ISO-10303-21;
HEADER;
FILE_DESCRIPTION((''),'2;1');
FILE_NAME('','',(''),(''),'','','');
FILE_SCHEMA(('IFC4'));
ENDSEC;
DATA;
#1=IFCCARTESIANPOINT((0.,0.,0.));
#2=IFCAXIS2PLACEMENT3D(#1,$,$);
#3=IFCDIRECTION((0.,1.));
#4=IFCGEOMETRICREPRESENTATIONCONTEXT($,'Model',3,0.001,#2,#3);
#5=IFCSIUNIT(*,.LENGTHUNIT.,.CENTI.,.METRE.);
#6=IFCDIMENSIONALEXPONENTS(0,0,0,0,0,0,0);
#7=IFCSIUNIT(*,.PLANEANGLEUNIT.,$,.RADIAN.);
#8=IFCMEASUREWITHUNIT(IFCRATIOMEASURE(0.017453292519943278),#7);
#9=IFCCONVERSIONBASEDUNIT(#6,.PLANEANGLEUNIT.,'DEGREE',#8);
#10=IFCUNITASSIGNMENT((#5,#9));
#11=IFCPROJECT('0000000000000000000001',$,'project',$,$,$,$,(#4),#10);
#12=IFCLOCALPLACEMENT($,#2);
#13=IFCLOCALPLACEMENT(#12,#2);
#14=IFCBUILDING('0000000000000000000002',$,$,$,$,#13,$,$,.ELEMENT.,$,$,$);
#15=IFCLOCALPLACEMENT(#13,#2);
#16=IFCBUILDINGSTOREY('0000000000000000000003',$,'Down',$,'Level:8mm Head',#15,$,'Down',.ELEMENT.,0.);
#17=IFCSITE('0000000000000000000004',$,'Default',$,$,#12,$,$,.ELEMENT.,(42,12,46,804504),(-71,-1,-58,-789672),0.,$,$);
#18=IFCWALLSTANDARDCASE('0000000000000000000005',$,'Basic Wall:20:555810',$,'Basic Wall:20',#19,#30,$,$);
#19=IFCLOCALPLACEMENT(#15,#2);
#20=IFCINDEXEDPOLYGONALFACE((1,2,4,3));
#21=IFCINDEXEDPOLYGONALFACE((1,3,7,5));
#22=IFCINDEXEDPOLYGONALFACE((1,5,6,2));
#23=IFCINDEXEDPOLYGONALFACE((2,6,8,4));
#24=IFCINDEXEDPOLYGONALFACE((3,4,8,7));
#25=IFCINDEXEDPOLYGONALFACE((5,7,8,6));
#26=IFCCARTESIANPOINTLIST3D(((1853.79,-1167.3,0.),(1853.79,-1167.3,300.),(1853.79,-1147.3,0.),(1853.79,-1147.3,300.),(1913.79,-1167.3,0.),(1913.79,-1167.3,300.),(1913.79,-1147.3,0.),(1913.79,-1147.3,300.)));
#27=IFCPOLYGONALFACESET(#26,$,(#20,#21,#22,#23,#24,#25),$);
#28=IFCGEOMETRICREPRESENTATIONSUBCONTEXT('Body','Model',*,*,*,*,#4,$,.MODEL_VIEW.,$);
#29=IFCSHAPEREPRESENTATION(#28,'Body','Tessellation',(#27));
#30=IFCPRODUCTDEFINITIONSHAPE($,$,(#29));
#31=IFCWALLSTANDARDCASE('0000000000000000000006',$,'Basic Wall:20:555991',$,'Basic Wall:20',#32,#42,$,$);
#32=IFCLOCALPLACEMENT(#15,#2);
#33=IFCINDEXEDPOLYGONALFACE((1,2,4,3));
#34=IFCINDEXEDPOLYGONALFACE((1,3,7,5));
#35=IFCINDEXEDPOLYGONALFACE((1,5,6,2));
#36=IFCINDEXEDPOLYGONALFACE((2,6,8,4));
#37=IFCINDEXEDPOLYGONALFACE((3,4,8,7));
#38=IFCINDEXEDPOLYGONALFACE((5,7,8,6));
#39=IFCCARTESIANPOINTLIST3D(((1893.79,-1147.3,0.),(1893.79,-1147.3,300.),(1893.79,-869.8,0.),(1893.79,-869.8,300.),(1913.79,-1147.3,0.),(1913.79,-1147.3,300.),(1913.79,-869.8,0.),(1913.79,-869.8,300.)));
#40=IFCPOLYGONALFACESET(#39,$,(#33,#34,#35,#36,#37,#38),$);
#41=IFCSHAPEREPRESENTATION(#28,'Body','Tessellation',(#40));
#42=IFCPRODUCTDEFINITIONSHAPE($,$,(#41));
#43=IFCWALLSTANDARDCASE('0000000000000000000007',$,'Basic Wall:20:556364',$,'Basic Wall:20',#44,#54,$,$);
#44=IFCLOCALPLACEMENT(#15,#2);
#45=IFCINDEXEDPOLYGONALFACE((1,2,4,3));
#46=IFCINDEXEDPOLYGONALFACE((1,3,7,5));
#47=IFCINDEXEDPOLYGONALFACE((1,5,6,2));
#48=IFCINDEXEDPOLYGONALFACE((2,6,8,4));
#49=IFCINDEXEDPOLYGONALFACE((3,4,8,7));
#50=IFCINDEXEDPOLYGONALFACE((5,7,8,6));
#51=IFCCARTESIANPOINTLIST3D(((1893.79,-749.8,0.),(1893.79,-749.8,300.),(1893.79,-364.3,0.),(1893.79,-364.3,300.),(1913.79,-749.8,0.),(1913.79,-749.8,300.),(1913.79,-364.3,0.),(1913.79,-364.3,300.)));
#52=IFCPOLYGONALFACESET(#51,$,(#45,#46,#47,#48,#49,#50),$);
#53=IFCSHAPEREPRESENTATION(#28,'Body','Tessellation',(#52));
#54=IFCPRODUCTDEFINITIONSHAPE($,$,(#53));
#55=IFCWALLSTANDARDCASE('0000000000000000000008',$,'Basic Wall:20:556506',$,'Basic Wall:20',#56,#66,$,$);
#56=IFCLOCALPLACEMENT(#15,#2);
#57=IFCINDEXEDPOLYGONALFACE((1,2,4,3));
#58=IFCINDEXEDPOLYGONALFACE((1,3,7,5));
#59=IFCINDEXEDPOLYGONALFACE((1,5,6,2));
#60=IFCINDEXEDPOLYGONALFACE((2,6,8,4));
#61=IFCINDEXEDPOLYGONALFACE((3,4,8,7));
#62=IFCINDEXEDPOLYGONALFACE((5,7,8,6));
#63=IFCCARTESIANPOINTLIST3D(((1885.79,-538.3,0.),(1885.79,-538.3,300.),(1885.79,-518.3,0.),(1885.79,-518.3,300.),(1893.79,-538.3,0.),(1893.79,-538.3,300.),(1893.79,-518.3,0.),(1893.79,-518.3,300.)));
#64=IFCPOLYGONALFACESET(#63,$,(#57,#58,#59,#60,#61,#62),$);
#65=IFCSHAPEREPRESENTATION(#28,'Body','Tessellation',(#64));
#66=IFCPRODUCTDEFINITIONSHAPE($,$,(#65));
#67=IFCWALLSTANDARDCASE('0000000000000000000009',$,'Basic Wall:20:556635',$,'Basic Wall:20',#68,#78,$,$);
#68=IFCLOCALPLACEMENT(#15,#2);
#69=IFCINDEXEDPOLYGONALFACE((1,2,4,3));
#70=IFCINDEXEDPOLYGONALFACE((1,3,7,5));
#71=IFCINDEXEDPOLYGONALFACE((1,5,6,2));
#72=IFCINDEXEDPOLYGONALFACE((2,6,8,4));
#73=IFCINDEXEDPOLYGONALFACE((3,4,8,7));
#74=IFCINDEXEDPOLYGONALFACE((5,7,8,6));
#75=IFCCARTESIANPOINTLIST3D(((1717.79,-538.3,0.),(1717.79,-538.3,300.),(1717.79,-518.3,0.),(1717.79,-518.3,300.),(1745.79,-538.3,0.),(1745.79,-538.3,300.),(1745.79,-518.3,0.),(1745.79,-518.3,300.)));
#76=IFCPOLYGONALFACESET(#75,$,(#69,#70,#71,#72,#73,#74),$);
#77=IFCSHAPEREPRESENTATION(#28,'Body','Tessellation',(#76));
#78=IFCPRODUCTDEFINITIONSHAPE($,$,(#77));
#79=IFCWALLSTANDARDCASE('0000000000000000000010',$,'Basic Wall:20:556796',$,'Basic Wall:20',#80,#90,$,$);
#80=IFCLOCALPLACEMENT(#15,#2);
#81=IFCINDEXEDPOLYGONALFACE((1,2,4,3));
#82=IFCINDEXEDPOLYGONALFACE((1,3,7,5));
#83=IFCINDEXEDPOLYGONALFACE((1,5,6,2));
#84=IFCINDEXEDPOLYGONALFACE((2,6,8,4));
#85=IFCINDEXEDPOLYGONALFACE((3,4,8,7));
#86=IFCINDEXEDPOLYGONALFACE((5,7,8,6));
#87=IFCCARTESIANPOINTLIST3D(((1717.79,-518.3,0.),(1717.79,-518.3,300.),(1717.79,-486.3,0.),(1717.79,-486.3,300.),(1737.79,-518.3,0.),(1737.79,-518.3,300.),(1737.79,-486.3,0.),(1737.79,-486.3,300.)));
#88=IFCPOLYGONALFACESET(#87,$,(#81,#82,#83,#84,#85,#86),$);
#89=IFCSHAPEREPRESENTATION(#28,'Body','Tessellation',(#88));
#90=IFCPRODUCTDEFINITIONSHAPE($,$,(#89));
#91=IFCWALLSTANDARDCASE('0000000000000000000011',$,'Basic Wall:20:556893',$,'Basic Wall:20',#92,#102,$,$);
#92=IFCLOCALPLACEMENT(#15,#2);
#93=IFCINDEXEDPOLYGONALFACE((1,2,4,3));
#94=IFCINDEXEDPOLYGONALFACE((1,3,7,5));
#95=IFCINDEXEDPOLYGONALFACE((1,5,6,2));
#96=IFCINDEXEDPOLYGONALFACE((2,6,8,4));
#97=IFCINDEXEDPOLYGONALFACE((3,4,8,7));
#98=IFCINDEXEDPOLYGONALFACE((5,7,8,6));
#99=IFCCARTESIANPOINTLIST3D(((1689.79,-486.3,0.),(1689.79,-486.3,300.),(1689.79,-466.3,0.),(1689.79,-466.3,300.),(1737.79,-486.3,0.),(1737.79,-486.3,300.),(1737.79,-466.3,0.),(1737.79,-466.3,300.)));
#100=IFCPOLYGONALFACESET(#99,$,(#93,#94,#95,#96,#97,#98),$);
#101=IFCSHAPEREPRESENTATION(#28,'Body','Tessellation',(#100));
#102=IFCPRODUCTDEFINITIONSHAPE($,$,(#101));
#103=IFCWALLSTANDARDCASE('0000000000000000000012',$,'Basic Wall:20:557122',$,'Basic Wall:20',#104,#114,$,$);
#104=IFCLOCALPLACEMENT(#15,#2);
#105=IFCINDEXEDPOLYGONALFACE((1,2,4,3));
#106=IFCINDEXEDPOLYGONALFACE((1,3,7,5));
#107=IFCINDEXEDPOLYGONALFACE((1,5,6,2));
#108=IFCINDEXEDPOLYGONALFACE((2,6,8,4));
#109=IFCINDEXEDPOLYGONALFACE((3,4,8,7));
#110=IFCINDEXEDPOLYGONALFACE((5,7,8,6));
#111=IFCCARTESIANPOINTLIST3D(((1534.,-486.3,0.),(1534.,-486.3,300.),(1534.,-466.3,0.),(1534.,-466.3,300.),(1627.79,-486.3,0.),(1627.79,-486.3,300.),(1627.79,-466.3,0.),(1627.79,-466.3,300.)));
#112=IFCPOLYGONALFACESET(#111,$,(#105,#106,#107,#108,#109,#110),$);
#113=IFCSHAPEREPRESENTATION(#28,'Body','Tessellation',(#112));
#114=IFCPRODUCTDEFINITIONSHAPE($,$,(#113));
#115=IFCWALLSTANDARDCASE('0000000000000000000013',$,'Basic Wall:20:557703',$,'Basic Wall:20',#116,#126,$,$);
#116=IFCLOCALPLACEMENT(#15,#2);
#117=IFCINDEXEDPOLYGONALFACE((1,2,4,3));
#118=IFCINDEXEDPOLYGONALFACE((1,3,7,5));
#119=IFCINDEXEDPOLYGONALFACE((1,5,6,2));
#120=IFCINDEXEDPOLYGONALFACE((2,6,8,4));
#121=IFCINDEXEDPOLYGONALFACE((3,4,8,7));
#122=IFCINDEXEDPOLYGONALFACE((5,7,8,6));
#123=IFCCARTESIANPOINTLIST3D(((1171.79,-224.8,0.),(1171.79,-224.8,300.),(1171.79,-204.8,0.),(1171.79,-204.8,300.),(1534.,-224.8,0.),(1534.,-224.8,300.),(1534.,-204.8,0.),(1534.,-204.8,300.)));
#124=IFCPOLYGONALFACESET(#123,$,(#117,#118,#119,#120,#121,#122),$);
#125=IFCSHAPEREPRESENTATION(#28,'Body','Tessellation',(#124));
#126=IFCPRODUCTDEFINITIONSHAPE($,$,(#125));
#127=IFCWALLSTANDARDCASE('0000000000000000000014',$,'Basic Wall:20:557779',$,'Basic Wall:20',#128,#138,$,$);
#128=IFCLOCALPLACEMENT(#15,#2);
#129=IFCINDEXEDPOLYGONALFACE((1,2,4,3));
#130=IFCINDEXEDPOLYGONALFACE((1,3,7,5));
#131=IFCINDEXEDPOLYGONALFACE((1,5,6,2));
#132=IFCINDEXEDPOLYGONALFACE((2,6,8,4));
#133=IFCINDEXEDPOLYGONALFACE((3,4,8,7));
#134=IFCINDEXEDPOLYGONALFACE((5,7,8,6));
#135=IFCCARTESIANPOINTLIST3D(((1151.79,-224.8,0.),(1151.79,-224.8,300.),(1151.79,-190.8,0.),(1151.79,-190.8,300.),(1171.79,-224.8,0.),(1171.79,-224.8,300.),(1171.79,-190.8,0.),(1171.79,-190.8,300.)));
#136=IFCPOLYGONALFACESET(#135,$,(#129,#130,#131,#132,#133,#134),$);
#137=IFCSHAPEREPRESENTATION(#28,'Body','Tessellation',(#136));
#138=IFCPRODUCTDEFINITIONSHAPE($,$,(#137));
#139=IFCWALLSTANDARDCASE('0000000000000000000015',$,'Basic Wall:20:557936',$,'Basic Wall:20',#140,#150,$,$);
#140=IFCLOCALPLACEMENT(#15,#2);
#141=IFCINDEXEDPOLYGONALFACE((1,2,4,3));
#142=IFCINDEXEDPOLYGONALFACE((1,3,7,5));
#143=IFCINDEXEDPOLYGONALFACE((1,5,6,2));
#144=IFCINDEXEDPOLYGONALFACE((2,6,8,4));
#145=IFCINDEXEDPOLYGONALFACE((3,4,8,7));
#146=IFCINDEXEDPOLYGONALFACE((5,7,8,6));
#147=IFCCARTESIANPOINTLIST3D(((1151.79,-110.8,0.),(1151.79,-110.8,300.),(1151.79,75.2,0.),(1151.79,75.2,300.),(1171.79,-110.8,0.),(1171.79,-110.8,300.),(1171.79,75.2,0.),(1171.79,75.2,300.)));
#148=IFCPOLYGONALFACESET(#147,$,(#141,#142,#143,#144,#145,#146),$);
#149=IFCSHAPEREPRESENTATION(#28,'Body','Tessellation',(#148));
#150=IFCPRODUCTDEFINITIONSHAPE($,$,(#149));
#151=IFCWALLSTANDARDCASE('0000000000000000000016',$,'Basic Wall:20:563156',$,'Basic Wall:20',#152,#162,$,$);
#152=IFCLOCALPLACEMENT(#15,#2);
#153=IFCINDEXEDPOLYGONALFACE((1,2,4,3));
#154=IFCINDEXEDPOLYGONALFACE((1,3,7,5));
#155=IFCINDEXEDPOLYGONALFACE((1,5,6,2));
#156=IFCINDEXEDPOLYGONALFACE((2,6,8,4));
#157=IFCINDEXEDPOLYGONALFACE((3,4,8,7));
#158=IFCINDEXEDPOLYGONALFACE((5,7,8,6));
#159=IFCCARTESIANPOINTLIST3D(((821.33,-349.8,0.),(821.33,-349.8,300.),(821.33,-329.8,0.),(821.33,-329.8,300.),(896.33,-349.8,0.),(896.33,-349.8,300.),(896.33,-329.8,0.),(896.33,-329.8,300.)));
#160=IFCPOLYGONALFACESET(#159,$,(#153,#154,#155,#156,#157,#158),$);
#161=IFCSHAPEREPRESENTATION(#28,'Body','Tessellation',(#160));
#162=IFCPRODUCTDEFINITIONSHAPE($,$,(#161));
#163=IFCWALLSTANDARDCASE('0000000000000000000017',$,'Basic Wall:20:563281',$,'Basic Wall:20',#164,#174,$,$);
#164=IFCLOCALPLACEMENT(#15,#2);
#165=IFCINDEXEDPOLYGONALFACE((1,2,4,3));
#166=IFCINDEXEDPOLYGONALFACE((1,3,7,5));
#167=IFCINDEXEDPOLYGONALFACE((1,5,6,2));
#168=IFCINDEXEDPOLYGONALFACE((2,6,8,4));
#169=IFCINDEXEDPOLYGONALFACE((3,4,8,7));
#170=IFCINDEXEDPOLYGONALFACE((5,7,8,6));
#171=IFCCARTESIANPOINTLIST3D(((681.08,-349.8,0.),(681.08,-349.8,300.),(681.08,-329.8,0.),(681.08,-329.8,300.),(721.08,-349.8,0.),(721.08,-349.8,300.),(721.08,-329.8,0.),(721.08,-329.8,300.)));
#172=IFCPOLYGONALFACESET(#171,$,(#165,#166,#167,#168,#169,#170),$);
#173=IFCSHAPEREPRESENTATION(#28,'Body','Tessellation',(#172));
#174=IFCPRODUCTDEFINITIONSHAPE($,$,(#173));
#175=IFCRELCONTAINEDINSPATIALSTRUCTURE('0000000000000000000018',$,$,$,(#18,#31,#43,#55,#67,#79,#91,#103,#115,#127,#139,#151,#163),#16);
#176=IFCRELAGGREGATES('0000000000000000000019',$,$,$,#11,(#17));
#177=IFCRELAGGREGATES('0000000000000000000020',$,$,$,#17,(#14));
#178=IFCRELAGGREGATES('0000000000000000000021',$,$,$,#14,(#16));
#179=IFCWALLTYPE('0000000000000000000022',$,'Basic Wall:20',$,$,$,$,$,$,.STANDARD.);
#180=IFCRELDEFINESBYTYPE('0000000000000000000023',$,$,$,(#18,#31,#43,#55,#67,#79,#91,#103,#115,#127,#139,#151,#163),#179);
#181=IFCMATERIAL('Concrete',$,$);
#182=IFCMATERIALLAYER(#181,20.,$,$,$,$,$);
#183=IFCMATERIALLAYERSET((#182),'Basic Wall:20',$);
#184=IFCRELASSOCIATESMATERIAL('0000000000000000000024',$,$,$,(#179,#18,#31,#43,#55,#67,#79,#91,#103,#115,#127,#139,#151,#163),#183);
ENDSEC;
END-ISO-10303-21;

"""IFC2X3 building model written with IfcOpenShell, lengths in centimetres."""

from ifc_helpers import new_model, entity, si_unit, converted_unit, direction, frame, frame_2d, origin, place, context, subcontext, project, spatial, rectangle, extrude, material, layer, layer_set, layer_usage, type_object, element, save


model = new_model("IFC2X3")

# Units and contexts
model_context = context("Model", 3, precision=0.001, world=origin(), true_north=direction((0.0, 1.0)))
body_context = subcontext(model_context, "Body", "Model", "MODEL_VIEW")
ifc_project = project(units=[si_unit("LENGTHUNIT", "METRE", prefix="CENTI"), converted_unit("PLANEANGLEUNIT", "DEGREE", entity("IfcRatioMeasure", 0.017453292519943278), si_unit("PLANEANGLEUNIT", "RADIAN"), dimensions=[0, 0, 0, 0, 0, 0, 0])], contexts=[model_context])

# Site, building, storey
site_placement = place(None, origin())
site = spatial("IfcSite", under=ifc_project, at=site_placement, Name="Default", CompositionType="ELEMENT", RefLatitude=(42, 12, 46, 804504), RefLongitude=(-71, -1, -58, -789672), RefElevation=0.0)
building_placement = place(site_placement, origin())
building = spatial("IfcBuilding", under=site, at=building_placement, CompositionType="ELEMENT")
storey_placement = place(building_placement, origin())
storey = spatial("IfcBuildingStorey", under=building, at=storey_placement, Name="Down", ObjectType="Level:8mm Head", LongName="Down", CompositionType="ELEMENT", Elevation=0.0)

# Walls
ifc_material = material(Name="Concrete")
ifc_layer_1 = layer(ifc_material, 20.0)
ifc_layer_set_1 = layer_set([ifc_layer_1], Name="Basic Wall:20")
wall_type_1 = type_object("IfcWallType", Name="Basic Wall:20", PredefinedType="STANDARD", material=ifc_layer_set_1)
ifc_layer_usage_1 = layer_usage(ifc_layer_set_1, "AXIS2", "NEGATIVE", 10.0)
wall_1_placement = place(storey_placement, frame((1853.79, -1157.3, 0.0)))
element("IfcWallStandardCase", 1, at=wall_1_placement, inside=storey, type_object=wall_type_1, material=ifc_layer_usage_1, Name="Basic Wall:20:555810", ObjectType="Basic Wall:20", context=body_context, shape_type="SweptSolid", body=[
    extrude(rectangle(XDim=60.0, YDim=20.0, at=frame_2d((30.0, 0.0), x_axis=(-1.0, 0.0))), origin(), (0.0, 0.0, 1.0), 300.0),
])
ifc_layer_usage_2 = layer_usage(ifc_layer_set_1, "AXIS2", "POSITIVE", -10.0)
wall_2_placement = place(storey_placement, frame((1903.79, -1147.3, 0.0), z_axis=(0.0, 0.0, 1.0), x_axis=(0.0, 1.0, 0.0)))
element("IfcWallStandardCase", 2, at=wall_2_placement, inside=storey, type_object=wall_type_1, material=ifc_layer_usage_2, Name="Basic Wall:20:555991", ObjectType="Basic Wall:20", context=body_context, shape_type="SweptSolid", body=[
    extrude(rectangle(XDim=277.5, YDim=20.0, at=frame_2d((138.75, 0.0), x_axis=(-1.0, 0.0))), origin(), (0.0, 0.0, 1.0), 300.0),
])
ifc_layer_usage_3 = layer_usage(ifc_layer_set_1, "AXIS2", "POSITIVE", -10.0)
wall_3_placement = place(storey_placement, frame((1903.79, -749.8, 0.0), z_axis=(0.0, 0.0, 1.0), x_axis=(0.0, 1.0, 0.0)))
element("IfcWallStandardCase", 3, at=wall_3_placement, inside=storey, type_object=wall_type_1, material=ifc_layer_usage_3, Name="Basic Wall:20:556364", ObjectType="Basic Wall:20", context=body_context, shape_type="SweptSolid", body=[
    extrude(rectangle(XDim=385.5, YDim=20.0, at=frame_2d((192.75, 0.0), x_axis=(-1.0, 0.0))), origin(), (0.0, 0.0, 1.0), 300.0),
])
ifc_layer_usage_4 = layer_usage(ifc_layer_set_1, "AXIS2", "POSITIVE", -10.0)
wall_4_placement = place(storey_placement, frame((1893.79, -528.3, 0.0), z_axis=(0.0, 0.0, 1.0), x_axis=(-1.0, 0.0, 0.0)))
element("IfcWallStandardCase", 4, at=wall_4_placement, inside=storey, type_object=wall_type_1, material=ifc_layer_usage_4, Name="Basic Wall:20:556506", ObjectType="Basic Wall:20", context=body_context, shape_type="SweptSolid", body=[
    extrude(rectangle(XDim=8.0, YDim=20.0, at=frame_2d((4.0, 0.0), x_axis=(-1.0, 0.0))), origin(), (0.0, 0.0, 1.0), 300.0),
])
ifc_layer_usage_5 = layer_usage(ifc_layer_set_1, "AXIS2", "POSITIVE", -10.0)
wall_5_placement = place(storey_placement, frame((1745.79, -528.3, 0.0), z_axis=(0.0, 0.0, 1.0), x_axis=(-1.0, 0.0, 0.0)))
element("IfcWallStandardCase", 5, at=wall_5_placement, inside=storey, type_object=wall_type_1, material=ifc_layer_usage_5, Name="Basic Wall:20:556635", ObjectType="Basic Wall:20", context=body_context, shape_type="SweptSolid", body=[
    extrude(rectangle(XDim=28.0, YDim=20.0, at=frame_2d((14.0, 0.0), x_axis=(-1.0, 0.0))), origin(), (0.0, 0.0, 1.0), 300.0),
])
ifc_layer_usage_6 = layer_usage(ifc_layer_set_1, "AXIS2", "NEGATIVE", 10.0)
wall_6_placement = place(storey_placement, frame((1727.79, -518.3, 0.0), z_axis=(0.0, 0.0, 1.0), x_axis=(0.0, 1.0, 0.0)))
element("IfcWallStandardCase", 6, at=wall_6_placement, inside=storey, type_object=wall_type_1, material=ifc_layer_usage_6, Name="Basic Wall:20:556796", ObjectType="Basic Wall:20", context=body_context, shape_type="SweptSolid", body=[
    extrude(rectangle(XDim=32.0, YDim=20.0, at=frame_2d((16.0, 0.0), x_axis=(-1.0, 0.0))), origin(), (0.0, 0.0, 1.0), 300.0),
])
ifc_layer_usage_7 = layer_usage(ifc_layer_set_1, "AXIS2", "POSITIVE", -10.0)
wall_7_placement = place(storey_placement, frame((1737.79, -476.3, 0.0), z_axis=(0.0, 0.0, 1.0), x_axis=(-1.0, 0.0, 0.0)))
element("IfcWallStandardCase", 7, at=wall_7_placement, inside=storey, type_object=wall_type_1, material=ifc_layer_usage_7, Name="Basic Wall:20:556893", ObjectType="Basic Wall:20", context=body_context, shape_type="SweptSolid", body=[
    extrude(rectangle(XDim=48.0, YDim=20.0, at=frame_2d((24.0, 0.0), x_axis=(-1.0, 0.0))), origin(), (0.0, 0.0, 1.0), 300.0),
])
ifc_layer_usage_8 = layer_usage(ifc_layer_set_1, "AXIS2", "POSITIVE", -10.0)
wall_8_placement = place(storey_placement, frame((1627.79, -476.3, 0.0), z_axis=(0.0, 0.0, 1.0), x_axis=(-1.0, 0.0, 0.0)))
element("IfcWallStandardCase", 8, at=wall_8_placement, inside=storey, type_object=wall_type_1, material=ifc_layer_usage_8, Name="Basic Wall:20:557122", ObjectType="Basic Wall:20", context=body_context, shape_type="SweptSolid", body=[
    extrude(rectangle(XDim=93.8, YDim=20.0, at=frame_2d((46.9, 0.0), x_axis=(-1.0, 0.0))), origin(), (0.0, 0.0, 1.0), 300.0),
])
ifc_layer_usage_9 = layer_usage(ifc_layer_set_1, "AXIS2", "POSITIVE", -10.0)
wall_9_placement = place(storey_placement, frame((1534.0, -214.8, 0.0), z_axis=(0.0, 0.0, 1.0), x_axis=(-1.0, 0.0, 0.0)))
element("IfcWallStandardCase", 9, at=wall_9_placement, inside=storey, type_object=wall_type_1, material=ifc_layer_usage_9, Name="Basic Wall:20:557703", ObjectType="Basic Wall:20", context=body_context, shape_type="SweptSolid", body=[
    extrude(rectangle(XDim=362.2, YDim=20.0, at=frame_2d((181.1, 0.0), x_axis=(-1.0, 0.0))), origin(), (0.0, 0.0, 1.0), 300.0),
])
ifc_layer_usage_10 = layer_usage(ifc_layer_set_1, "AXIS2", "NEGATIVE", 10.0)
wall_10_placement = place(storey_placement, frame((1161.79, -224.8, 0.0), z_axis=(0.0, 0.0, 1.0), x_axis=(0.0, 1.0, 0.0)))
element("IfcWallStandardCase", 10, at=wall_10_placement, inside=storey, type_object=wall_type_1, material=ifc_layer_usage_10, Name="Basic Wall:20:557779", ObjectType="Basic Wall:20", context=body_context, shape_type="SweptSolid", body=[
    extrude(rectangle(XDim=34.0, YDim=20.0, at=frame_2d((17.0, 0.0), x_axis=(-1.0, 0.0))), origin(), (0.0, 0.0, 1.0), 300.0),
])
ifc_layer_usage_11 = layer_usage(ifc_layer_set_1, "AXIS2", "NEGATIVE", 10.0)
wall_11_placement = place(storey_placement, frame((1161.79, -110.8, 0.0), z_axis=(0.0, 0.0, 1.0), x_axis=(0.0, 1.0, 0.0)))
element("IfcWallStandardCase", 11, at=wall_11_placement, inside=storey, type_object=wall_type_1, material=ifc_layer_usage_11, Name="Basic Wall:20:557936", ObjectType="Basic Wall:20", context=body_context, shape_type="SweptSolid", body=[
    extrude(rectangle(XDim=186.0, YDim=20.0, at=frame_2d((93.0, 0.0), x_axis=(-1.0, 0.0))), origin(), (0.0, 0.0, 1.0), 300.0),
])
ifc_layer_usage_12 = layer_usage(ifc_layer_set_1, "AXIS2", "NEGATIVE", 10.0)
wall_12_placement = place(storey_placement, frame((896.33, -339.8, 0.0), z_axis=(0.0, 0.0, 1.0), x_axis=(-1.0, 0.0, 0.0)))
element("IfcWallStandardCase", 12, at=wall_12_placement, inside=storey, type_object=wall_type_1, material=ifc_layer_usage_12, Name="Basic Wall:20:563156", ObjectType="Basic Wall:20", context=body_context, shape_type="SweptSolid", body=[
    extrude(rectangle(XDim=75.0, YDim=20.0, at=frame_2d((37.5, 0.0), x_axis=(-1.0, 0.0))), origin(), (0.0, 0.0, 1.0), 300.0),
])
ifc_layer_usage_13 = layer_usage(ifc_layer_set_1, "AXIS2", "NEGATIVE", 10.0)
wall_13_placement = place(storey_placement, frame((721.08, -339.8, 0.0), z_axis=(0.0, 0.0, 1.0), x_axis=(-1.0, 0.0, 0.0)))
element("IfcWallStandardCase", 13, at=wall_13_placement, inside=storey, type_object=wall_type_1, material=ifc_layer_usage_13, Name="Basic Wall:20:563281", ObjectType="Basic Wall:20", context=body_context, shape_type="SweptSolid", body=[
    extrude(rectangle(XDim=40.0, YDim=20.0, at=frame_2d((20.0, 0.0), x_axis=(-1.0, 0.0))), origin(), (0.0, 0.0, 1.0), 300.0),
])

save(model, "model.ifc")
